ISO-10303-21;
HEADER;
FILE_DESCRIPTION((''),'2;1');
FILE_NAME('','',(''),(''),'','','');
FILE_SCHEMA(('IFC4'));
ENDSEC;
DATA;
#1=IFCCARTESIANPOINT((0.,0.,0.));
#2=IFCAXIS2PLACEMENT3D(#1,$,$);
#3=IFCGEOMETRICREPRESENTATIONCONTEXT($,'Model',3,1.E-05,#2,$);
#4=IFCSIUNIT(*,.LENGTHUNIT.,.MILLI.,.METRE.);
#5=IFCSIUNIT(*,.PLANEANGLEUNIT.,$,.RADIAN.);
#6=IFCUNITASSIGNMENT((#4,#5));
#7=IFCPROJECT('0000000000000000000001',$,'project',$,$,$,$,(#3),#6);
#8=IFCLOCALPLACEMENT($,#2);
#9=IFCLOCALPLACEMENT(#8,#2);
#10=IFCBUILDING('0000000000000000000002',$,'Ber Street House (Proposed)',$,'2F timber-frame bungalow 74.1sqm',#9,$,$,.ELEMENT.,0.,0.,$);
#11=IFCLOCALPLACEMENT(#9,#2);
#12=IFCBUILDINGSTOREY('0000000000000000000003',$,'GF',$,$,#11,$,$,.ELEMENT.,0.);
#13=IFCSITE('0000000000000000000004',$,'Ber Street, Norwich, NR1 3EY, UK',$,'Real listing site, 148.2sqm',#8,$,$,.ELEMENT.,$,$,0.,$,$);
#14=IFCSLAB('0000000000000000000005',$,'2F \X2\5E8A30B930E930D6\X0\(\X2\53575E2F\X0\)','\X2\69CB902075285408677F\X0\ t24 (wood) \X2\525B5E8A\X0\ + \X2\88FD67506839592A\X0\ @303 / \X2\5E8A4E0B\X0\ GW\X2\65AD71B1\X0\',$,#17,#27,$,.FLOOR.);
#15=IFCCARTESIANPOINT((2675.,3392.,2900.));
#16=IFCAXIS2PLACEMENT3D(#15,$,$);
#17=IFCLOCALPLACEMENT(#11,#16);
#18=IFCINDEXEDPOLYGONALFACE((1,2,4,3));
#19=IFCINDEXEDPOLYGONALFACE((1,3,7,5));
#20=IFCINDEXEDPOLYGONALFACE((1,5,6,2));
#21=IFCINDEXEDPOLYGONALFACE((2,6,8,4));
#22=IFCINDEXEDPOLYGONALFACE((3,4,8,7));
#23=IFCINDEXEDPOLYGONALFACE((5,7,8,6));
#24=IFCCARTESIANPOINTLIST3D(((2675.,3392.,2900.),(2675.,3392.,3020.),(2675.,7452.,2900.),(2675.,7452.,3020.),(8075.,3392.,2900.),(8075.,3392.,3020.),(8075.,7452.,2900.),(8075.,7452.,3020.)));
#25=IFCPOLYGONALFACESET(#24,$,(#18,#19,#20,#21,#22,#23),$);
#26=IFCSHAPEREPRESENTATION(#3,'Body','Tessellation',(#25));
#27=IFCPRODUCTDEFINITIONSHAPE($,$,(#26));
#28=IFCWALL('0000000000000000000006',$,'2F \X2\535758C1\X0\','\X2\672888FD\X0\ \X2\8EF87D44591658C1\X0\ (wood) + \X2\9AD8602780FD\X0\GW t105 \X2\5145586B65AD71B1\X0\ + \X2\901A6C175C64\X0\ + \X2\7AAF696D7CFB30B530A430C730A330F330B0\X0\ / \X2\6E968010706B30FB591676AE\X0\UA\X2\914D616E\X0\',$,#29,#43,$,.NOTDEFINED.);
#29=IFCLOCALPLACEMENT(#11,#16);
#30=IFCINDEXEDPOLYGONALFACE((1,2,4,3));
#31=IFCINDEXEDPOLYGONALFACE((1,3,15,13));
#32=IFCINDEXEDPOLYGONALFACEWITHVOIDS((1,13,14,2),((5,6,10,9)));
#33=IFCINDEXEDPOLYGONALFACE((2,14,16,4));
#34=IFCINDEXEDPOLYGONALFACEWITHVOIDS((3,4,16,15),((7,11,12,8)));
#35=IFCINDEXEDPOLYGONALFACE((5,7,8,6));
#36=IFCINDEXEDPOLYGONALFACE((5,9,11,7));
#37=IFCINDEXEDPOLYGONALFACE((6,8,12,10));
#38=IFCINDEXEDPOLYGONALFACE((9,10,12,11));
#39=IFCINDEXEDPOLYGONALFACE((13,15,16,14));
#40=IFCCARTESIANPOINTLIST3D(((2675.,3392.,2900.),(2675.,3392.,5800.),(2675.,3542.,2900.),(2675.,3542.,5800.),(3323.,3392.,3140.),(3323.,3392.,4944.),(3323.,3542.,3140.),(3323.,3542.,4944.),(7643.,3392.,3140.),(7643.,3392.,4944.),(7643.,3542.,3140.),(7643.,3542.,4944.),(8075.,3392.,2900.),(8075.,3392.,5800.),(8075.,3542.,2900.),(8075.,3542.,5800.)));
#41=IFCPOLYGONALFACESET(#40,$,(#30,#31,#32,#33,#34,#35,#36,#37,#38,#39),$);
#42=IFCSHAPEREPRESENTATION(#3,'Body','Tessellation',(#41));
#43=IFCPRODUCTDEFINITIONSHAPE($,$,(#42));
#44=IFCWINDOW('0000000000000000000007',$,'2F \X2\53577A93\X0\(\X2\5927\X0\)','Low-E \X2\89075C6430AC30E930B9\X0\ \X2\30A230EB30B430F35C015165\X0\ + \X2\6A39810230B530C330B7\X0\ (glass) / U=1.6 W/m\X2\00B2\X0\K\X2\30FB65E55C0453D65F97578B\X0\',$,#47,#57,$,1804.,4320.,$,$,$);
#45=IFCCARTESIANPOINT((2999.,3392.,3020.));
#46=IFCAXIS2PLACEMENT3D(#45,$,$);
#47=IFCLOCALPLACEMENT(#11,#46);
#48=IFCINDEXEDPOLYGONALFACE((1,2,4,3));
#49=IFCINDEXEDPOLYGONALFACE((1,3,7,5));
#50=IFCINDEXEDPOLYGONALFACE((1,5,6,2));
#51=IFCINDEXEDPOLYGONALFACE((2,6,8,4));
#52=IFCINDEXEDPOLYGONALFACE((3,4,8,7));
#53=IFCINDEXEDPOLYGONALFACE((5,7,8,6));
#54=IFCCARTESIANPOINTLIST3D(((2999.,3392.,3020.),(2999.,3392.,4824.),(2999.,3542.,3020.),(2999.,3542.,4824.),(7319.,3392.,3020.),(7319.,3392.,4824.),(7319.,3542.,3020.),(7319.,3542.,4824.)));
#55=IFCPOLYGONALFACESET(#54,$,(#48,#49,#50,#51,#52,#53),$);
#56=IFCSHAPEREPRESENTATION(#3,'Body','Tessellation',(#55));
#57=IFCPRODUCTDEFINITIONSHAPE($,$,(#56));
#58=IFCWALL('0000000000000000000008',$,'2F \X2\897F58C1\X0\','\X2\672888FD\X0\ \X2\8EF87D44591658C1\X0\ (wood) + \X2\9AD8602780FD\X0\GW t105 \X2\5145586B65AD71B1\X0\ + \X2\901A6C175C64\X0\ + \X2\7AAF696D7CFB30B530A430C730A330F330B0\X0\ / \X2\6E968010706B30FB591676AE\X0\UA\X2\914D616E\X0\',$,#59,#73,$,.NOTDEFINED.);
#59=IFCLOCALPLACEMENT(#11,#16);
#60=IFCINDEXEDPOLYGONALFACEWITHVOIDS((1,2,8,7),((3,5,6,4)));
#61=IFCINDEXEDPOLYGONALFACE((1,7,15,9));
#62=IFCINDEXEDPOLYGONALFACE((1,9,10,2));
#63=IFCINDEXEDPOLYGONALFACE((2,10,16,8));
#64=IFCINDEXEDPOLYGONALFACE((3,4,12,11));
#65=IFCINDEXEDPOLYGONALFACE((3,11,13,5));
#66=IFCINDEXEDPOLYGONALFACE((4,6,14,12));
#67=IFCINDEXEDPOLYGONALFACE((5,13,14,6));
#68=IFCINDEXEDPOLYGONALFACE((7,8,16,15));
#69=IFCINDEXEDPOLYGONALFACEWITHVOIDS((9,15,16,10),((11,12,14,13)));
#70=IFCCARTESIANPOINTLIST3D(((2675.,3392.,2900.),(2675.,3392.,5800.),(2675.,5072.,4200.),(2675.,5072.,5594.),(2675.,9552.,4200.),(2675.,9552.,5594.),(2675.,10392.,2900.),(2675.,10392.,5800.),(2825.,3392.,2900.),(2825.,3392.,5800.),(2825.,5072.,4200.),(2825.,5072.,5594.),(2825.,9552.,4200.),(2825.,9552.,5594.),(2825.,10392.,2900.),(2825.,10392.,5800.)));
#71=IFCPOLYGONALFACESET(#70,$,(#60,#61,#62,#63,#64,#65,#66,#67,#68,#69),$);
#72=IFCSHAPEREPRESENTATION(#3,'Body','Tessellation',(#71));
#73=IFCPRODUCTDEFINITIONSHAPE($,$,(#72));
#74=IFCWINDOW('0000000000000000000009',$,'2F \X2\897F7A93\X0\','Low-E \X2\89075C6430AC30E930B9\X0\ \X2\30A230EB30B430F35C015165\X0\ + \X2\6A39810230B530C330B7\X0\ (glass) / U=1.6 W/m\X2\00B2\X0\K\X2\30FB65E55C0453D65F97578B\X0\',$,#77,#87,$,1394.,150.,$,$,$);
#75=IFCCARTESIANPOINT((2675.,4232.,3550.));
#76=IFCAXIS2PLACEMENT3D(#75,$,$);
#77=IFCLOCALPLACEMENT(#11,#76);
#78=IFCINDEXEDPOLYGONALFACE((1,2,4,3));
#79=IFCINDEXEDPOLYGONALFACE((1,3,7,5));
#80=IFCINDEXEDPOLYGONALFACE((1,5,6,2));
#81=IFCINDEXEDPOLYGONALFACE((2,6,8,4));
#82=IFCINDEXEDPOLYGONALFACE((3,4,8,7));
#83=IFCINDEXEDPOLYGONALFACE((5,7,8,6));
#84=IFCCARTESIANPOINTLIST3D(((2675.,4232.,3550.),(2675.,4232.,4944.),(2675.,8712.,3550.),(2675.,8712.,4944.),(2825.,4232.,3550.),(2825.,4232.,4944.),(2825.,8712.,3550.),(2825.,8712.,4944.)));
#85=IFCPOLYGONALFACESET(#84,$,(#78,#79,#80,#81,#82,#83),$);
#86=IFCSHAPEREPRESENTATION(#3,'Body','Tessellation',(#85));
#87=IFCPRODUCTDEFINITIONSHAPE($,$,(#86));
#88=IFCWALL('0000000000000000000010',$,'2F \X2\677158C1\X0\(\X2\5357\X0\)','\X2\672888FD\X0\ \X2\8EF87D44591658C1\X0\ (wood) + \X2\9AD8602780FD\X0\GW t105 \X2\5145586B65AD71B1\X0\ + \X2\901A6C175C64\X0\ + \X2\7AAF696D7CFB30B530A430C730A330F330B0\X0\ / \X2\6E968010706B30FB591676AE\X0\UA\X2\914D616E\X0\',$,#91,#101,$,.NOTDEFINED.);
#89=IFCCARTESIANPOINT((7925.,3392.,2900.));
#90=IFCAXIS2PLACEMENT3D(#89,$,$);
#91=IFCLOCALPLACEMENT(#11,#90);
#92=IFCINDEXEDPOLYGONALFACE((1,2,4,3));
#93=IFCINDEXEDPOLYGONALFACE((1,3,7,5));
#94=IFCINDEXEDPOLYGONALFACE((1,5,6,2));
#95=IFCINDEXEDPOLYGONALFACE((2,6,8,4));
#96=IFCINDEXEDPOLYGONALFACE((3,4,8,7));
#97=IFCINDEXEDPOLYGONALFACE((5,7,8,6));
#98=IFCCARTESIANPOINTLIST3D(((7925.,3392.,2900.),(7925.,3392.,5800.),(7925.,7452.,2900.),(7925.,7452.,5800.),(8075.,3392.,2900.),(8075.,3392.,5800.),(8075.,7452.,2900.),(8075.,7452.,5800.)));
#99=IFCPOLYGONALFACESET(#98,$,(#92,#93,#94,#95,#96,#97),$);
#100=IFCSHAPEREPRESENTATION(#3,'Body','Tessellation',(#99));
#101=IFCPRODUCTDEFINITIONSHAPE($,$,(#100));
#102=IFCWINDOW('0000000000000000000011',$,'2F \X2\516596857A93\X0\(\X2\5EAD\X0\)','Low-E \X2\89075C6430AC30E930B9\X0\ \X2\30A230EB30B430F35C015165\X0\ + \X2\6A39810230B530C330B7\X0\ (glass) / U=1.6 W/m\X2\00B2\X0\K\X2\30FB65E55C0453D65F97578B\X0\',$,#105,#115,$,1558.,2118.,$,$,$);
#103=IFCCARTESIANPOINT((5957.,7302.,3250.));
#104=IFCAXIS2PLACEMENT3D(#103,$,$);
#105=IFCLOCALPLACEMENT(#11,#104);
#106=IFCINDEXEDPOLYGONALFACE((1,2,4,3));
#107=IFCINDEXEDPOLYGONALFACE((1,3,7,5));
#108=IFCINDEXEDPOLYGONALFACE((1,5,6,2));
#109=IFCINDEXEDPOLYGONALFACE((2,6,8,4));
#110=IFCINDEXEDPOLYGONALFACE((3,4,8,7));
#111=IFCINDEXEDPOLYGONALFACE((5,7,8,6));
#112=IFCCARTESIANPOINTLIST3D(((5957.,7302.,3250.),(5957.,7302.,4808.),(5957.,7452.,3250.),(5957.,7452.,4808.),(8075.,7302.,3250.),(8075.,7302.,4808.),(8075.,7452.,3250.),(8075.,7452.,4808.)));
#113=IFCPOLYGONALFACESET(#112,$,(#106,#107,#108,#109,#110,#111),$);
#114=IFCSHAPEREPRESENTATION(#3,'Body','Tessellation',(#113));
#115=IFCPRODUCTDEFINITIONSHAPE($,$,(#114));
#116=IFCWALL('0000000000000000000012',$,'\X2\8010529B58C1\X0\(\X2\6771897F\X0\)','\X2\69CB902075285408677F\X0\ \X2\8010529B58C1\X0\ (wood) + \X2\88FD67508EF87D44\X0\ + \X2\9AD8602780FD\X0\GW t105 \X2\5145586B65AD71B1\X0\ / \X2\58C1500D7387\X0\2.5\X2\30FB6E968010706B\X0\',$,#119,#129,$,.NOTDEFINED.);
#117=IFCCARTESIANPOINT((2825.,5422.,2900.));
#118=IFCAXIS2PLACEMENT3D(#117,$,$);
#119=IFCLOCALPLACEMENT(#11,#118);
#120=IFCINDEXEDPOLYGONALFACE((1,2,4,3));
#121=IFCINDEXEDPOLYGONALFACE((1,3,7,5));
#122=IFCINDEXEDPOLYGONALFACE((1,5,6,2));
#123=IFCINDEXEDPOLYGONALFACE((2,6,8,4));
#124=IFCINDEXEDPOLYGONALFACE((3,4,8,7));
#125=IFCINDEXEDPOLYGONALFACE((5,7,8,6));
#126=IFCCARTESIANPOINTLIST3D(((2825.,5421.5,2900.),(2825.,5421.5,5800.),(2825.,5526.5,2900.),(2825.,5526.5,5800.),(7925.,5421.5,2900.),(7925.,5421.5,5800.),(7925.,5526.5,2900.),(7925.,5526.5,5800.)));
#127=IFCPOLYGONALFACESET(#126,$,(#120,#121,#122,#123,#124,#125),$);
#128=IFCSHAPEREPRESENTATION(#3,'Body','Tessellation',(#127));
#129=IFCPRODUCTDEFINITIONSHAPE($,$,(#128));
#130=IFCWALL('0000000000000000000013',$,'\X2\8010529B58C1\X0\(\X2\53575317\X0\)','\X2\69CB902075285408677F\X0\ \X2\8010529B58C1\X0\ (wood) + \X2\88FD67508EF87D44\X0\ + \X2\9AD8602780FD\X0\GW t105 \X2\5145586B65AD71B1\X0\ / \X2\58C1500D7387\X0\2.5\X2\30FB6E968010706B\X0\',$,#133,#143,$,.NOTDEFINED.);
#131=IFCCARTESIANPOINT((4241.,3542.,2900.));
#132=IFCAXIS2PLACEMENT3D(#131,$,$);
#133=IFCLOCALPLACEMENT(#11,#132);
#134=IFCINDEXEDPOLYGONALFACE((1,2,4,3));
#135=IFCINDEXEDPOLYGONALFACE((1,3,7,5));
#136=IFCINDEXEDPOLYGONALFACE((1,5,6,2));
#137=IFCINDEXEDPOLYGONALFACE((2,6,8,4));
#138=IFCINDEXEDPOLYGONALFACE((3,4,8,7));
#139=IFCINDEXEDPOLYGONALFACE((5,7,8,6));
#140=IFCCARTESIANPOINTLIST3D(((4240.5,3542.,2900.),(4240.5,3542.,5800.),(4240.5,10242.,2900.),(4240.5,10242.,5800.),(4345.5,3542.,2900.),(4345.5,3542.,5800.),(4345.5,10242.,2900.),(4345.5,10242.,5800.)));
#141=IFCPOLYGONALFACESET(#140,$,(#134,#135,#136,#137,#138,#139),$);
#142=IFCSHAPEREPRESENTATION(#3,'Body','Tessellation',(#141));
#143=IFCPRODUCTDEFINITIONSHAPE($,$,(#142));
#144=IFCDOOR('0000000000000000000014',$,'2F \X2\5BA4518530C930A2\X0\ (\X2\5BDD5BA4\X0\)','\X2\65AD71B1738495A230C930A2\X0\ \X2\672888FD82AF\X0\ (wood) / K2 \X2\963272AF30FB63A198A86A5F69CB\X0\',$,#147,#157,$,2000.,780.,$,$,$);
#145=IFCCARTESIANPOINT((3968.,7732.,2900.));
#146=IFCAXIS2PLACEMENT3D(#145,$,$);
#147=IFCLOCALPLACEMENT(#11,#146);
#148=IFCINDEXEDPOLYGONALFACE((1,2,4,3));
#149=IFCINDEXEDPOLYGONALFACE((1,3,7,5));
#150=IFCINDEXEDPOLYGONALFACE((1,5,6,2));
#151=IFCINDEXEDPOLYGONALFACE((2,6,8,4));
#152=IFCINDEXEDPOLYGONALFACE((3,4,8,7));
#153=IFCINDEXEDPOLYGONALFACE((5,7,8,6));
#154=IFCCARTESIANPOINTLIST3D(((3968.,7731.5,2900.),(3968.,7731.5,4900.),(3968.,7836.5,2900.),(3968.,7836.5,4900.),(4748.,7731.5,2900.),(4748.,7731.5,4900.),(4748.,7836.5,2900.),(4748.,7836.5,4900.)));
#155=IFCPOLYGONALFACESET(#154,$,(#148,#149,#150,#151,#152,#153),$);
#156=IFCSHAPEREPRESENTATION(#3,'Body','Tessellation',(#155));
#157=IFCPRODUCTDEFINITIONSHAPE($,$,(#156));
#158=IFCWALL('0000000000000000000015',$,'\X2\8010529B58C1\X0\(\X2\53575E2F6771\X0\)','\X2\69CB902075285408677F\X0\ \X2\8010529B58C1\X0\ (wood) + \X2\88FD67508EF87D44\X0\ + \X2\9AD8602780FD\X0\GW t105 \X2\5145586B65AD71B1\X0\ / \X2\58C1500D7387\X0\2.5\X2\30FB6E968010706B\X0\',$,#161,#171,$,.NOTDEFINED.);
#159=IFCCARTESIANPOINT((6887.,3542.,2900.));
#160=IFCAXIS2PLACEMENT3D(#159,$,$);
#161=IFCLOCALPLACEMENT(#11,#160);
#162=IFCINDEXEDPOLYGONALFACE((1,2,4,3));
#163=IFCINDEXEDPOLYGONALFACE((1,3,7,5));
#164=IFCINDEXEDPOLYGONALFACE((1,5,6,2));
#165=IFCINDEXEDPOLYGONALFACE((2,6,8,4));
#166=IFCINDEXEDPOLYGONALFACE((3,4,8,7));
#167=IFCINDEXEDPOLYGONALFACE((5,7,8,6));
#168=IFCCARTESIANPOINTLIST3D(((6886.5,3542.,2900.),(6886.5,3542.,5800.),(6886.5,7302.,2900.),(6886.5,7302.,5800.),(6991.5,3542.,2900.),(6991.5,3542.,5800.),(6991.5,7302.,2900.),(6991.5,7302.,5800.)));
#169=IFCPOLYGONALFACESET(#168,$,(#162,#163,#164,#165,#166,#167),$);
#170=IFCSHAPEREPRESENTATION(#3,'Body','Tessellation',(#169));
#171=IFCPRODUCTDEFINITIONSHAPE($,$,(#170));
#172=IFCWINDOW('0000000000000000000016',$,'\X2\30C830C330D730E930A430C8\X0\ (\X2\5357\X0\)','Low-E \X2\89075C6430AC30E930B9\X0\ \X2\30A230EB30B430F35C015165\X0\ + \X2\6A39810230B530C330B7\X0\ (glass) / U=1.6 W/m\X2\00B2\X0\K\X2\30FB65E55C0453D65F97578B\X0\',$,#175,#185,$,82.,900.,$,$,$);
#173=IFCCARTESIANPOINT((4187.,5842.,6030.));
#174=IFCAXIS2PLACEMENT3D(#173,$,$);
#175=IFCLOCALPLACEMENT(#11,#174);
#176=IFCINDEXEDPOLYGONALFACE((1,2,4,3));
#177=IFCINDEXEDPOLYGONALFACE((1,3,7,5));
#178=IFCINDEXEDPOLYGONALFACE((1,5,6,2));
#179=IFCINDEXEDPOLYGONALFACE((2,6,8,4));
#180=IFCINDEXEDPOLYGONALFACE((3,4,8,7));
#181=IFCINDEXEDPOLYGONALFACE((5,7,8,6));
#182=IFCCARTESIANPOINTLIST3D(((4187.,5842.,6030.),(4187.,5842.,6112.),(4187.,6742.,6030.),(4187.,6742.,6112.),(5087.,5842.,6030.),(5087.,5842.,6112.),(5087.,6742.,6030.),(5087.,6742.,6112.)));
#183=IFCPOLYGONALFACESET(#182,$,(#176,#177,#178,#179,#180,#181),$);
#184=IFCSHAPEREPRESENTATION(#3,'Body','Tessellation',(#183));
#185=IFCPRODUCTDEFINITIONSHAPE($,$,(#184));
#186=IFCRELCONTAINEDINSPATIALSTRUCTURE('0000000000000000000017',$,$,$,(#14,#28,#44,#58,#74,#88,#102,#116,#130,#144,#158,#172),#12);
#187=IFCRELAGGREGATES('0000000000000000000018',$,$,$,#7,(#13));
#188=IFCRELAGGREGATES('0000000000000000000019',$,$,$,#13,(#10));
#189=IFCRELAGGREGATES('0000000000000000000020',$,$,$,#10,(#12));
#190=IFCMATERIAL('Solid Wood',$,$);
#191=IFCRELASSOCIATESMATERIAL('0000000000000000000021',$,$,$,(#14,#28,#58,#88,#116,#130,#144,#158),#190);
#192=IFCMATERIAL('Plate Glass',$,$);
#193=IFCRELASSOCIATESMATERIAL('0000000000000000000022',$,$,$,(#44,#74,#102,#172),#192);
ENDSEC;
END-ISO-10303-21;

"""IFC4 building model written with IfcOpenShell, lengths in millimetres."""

from ifc_helpers import new_model, si_unit, frame, frame_2d, origin, place, context, project, spatial, rectangle, extrude, material, element, fill, save


model = new_model("IFC4")

# Units and contexts
model_context = context("Model", 3, precision=1e-05, world=origin())
ifc_project = project(units=[si_unit("LENGTHUNIT", "METRE", prefix="MILLI"), si_unit("PLANEANGLEUNIT", "RADIAN")], contexts=[model_context])

# Site, building, storey
site_placement = place(None, origin())
site = spatial("IfcSite", under=ifc_project, at=site_placement, Name="Ber Street, Norwich, NR1 3EY, UK", ObjectType="Real listing site, 148.2sqm", CompositionType="ELEMENT", RefElevation=0.0)
building_placement = place(site_placement, origin())
building = spatial("IfcBuilding", under=site, at=building_placement, Name="Ber Street House (Proposed)", ObjectType="2F timber-frame bungalow 74.1sqm", CompositionType="ELEMENT", ElevationOfRefHeight=0.0, ElevationOfTerrain=0.0)
storey_placement = place(building_placement, origin())
storey = spatial("IfcBuildingStorey", under=building, at=storey_placement, Name="GF", CompositionType="ELEMENT", Elevation=0.0)

# Slab
ifc_material_1 = material(Name="Solid Wood")
slab_placement = place(storey_placement, frame((2675.0, 3392.0, 2900.0)))
element("IfcSlab", 1, at=slab_placement, inside=storey, material=ifc_material_1, Name="2F 床スラブ(南帯)", Description="構造用合板 t24 (wood) 剛床 + 製材根太 @303 / 床下 GW断熱", PredefinedType="FLOOR", context=model_context, shape_type="SweptSolid", body=[
    extrude(rectangle(XDim=5400.0, YDim=4060.0, at=frame_2d((2700.0, 2030.0))), frame((2675.0, 3392.0, 2900.0)), (0.0, 0.0, 1.0), 120.0),
])

# Walls, openings, windows
wall_1_placement = place(storey_placement, frame((2675.0, 3392.0, 2900.0)))
wall_1 = element("IfcWall", 2, at=wall_1_placement, inside=storey, material=ifc_material_1, Name="2F 南壁", Description="木製 軸組外壁 (wood) + 高性能GW t105 充填断熱 + 通気層 + 窯業系サイディング / 準耐火・外皮UA配慮", PredefinedType="NOTDEFINED", context=model_context, shape_type="SweptSolid", body=[
    extrude(rectangle(XDim=5400.0, YDim=150.0, at=frame_2d((2700.0, 75.0))), frame((2675.0, 3392.0, 2900.0)), (0.0, 0.0, 1.0), 2900.0),
])
opening_1_placement = place(storey_placement, frame((2999.0, 3392.0, 3020.0)))
opening_1 = element("IfcOpeningElement", 3, at=opening_1_placement, cuts=wall_1, PredefinedType="NOTDEFINED", context=model_context, shape_type="SweptSolid", body=[
    extrude(rectangle(XDim=4320.0, YDim=150.0, at=frame_2d((2160.0, 75.0))), frame((2999.0, 3392.0, 3020.0)), (0.0, 0.0, 1.0), 1804.0),
])
ifc_material_2 = material(Name="Plate Glass")
window_1_placement = place(storey_placement, frame((2999.0, 3392.0, 3020.0)))
window_1 = element("IfcWindow", 4, at=window_1_placement, inside=storey, material=ifc_material_2, Name="2F 南窓(大)", Description="Low-E 複層ガラス アルゴン封入 + 樹脂サッシ (glass) / U=1.6 W/m²K・日射取得型", OverallHeight=1804.0, OverallWidth=4320.0, context=model_context, shape_type="SweptSolid", body=[
    extrude(rectangle(XDim=4320.0, YDim=150.0, at=frame_2d((2160.0, 75.0))), frame((2999.0, 3392.0, 3020.0)), (0.0, 0.0, 1.0), 1804.0),
])
fill(opening_1, window_1)
wall_2_placement = place(storey_placement, frame((2675.0, 3392.0, 2900.0)))
wall_2 = element("IfcWall", 5, at=wall_2_placement, inside=storey, material=ifc_material_1, Name="2F 西壁", Description="木製 軸組外壁 (wood) + 高性能GW t105 充填断熱 + 通気層 + 窯業系サイディング / 準耐火・外皮UA配慮", PredefinedType="NOTDEFINED", context=model_context, shape_type="SweptSolid", body=[
    extrude(rectangle(XDim=150.0, YDim=7000.0, at=frame_2d((75.0, 3500.0))), frame((2675.0, 3392.0, 2900.0)), (0.0, 0.0, 1.0), 2900.0),
])
opening_2_placement = place(storey_placement, frame((2675.0, 4232.0, 3550.0)))
opening_2 = element("IfcOpeningElement", 6, at=opening_2_placement, cuts=wall_2, PredefinedType="NOTDEFINED", context=model_context, shape_type="SweptSolid", body=[
    extrude(rectangle(XDim=150.0, YDim=4480.0, at=frame_2d((75.0, 2240.0))), frame((2675.0, 4232.0, 3550.0)), (0.0, 0.0, 1.0), 1394.0),
])
window_2_placement = place(storey_placement, frame((2675.0, 4232.0, 3550.0)))
window_2 = element("IfcWindow", 7, at=window_2_placement, inside=storey, material=ifc_material_2, Name="2F 西窓", Description="Low-E 複層ガラス アルゴン封入 + 樹脂サッシ (glass) / U=1.6 W/m²K・日射取得型", OverallHeight=1394.0, OverallWidth=150.0, context=model_context, shape_type="SweptSolid", body=[
    extrude(rectangle(XDim=150.0, YDim=4480.0, at=frame_2d((75.0, 2240.0))), frame((2675.0, 4232.0, 3550.0)), (0.0, 0.0, 1.0), 1394.0),
])
fill(opening_2, window_2)
wall_3_placement = place(storey_placement, frame((7925.0, 3392.0, 2900.0)))
wall_3 = element("IfcWall", 8, at=wall_3_placement, inside=storey, material=ifc_material_1, Name="2F 東壁(南)", Description="木製 軸組外壁 (wood) + 高性能GW t105 充填断熱 + 通気層 + 窯業系サイディング / 準耐火・外皮UA配慮", PredefinedType="NOTDEFINED", context=model_context, shape_type="SweptSolid", body=[
    extrude(rectangle(XDim=150.0, YDim=4060.0, at=frame_2d((75.0, 2030.0))), frame((7925.0, 3392.0, 2900.0)), (0.0, 0.0, 1.0), 2900.0),
])
opening_3_placement = place(storey_placement, frame((5957.0, 7302.0, 3250.0)))
opening_3 = element("IfcOpeningElement", 9, at=opening_3_placement, cuts=wall_3, PredefinedType="NOTDEFINED", context=model_context, shape_type="SweptSolid", body=[
    extrude(rectangle(XDim=2118.0, YDim=150.0, at=frame_2d((1059.0, 75.0))), frame((5957.0, 7302.0, 3250.0)), (0.0, 0.0, 1.0), 1558.0),
])
window_3_placement = place(storey_placement, frame((5957.0, 7302.0, 3250.0)))
window_3 = element("IfcWindow", 10, at=window_3_placement, inside=storey, material=ifc_material_2, Name="2F 入隅窓(庭)", Description="Low-E 複層ガラス アルゴン封入 + 樹脂サッシ (glass) / U=1.6 W/m²K・日射取得型", OverallHeight=1558.0, OverallWidth=2118.0, context=model_context, shape_type="SweptSolid", body=[
    extrude(rectangle(XDim=2118.0, YDim=150.0, at=frame_2d((1059.0, 75.0))), frame((5957.0, 7302.0, 3250.0)), (0.0, 0.0, 1.0), 1558.0),
])
fill(opening_3, window_3)

# Wall
wall_4_placement = place(storey_placement, frame((2825.0, 5422.0, 2900.0)))
element("IfcWall", 11, at=wall_4_placement, inside=storey, material=ifc_material_1, Name="耐力壁(東西)", Description="構造用合板 耐力壁 (wood) + 製材軸組 + 高性能GW t105 充填断熱 / 壁倍率2.5・準耐火", PredefinedType="NOTDEFINED", context=model_context, shape_type="SweptSolid", body=[
    extrude(rectangle(XDim=5100.0, YDim=105.0, at=frame_2d((2550.0, 52.0))), frame((2825.0, 5422.0, 2900.0)), (0.0, 0.0, 1.0), 2900.0),
])

# Wall, opening, door
wall_5_placement = place(storey_placement, frame((4241.0, 3542.0, 2900.0)))
wall_5 = element("IfcWall", 12, at=wall_5_placement, inside=storey, material=ifc_material_1, Name="耐力壁(南北)", Description="構造用合板 耐力壁 (wood) + 製材軸組 + 高性能GW t105 充填断熱 / 壁倍率2.5・準耐火", PredefinedType="NOTDEFINED", context=model_context, shape_type="SweptSolid", body=[
    extrude(rectangle(XDim=105.0, YDim=6700.0, at=frame_2d((52.0, 3350.0))), frame((4241.0, 3542.0, 2900.0)), (0.0, 0.0, 1.0), 2900.0),
])
opening_4_placement = place(storey_placement, frame((3968.0, 7732.0, 2900.0)))
opening_4 = element("IfcOpeningElement", 13, at=opening_4_placement, cuts=wall_5, PredefinedType="NOTDEFINED", context=model_context, shape_type="SweptSolid", body=[
    extrude(rectangle(XDim=780.0, YDim=105.0, at=frame_2d((390.0, 52.0))), frame((3968.0, 7732.0, 2900.0)), (0.0, 0.0, 1.0), 2000.0),
])
door_placement = place(storey_placement, frame((3968.0, 7732.0, 2900.0)))
door = element("IfcDoor", 14, at=door_placement, inside=storey, material=ifc_material_1, Name="2F 室内ドア (寝室)", Description="断熱玄関ドア 木製芯 (wood) / K2 防犯・採風機構", OverallHeight=2000.0, OverallWidth=780.0, context=model_context, shape_type="SweptSolid", body=[
    extrude(rectangle(XDim=780.0, YDim=105.0, at=frame_2d((390.0, 52.0))), frame((3968.0, 7732.0, 2900.0)), (0.0, 0.0, 1.0), 2000.0),
])
fill(opening_4, door)

# Wall
wall_6_placement = place(storey_placement, frame((6887.0, 3542.0, 2900.0)))
element("IfcWall", 15, at=wall_6_placement, inside=storey, material=ifc_material_1, Name="耐力壁(南帯東)", Description="構造用合板 耐力壁 (wood) + 製材軸組 + 高性能GW t105 充填断熱 / 壁倍率2.5・準耐火", PredefinedType="NOTDEFINED", context=model_context, shape_type="SweptSolid", body=[
    extrude(rectangle(XDim=105.0, YDim=3760.0, at=frame_2d((52.0, 1880.0))), frame((6887.0, 3542.0, 2900.0)), (0.0, 0.0, 1.0), 2900.0),
])

# Window
window_4_placement = place(storey_placement, frame((4187.0, 5842.0, 6030.0)))
element("IfcWindow", 16, at=window_4_placement, inside=storey, material=ifc_material_2, Name="トップライト (南)", Description="Low-E 複層ガラス アルゴン封入 + 樹脂サッシ (glass) / U=1.6 W/m²K・日射取得型", OverallHeight=82.0, OverallWidth=900.0, context=model_context, shape_type="SweptSolid", body=[
    extrude(rectangle(XDim=900.0, YDim=900.0, at=frame_2d((450.0, 450.0))), frame((4187.0, 5842.0, 6030.0)), (0.0, 0.0, 1.0), 82.0),
])

save(model, "model.ifc")
